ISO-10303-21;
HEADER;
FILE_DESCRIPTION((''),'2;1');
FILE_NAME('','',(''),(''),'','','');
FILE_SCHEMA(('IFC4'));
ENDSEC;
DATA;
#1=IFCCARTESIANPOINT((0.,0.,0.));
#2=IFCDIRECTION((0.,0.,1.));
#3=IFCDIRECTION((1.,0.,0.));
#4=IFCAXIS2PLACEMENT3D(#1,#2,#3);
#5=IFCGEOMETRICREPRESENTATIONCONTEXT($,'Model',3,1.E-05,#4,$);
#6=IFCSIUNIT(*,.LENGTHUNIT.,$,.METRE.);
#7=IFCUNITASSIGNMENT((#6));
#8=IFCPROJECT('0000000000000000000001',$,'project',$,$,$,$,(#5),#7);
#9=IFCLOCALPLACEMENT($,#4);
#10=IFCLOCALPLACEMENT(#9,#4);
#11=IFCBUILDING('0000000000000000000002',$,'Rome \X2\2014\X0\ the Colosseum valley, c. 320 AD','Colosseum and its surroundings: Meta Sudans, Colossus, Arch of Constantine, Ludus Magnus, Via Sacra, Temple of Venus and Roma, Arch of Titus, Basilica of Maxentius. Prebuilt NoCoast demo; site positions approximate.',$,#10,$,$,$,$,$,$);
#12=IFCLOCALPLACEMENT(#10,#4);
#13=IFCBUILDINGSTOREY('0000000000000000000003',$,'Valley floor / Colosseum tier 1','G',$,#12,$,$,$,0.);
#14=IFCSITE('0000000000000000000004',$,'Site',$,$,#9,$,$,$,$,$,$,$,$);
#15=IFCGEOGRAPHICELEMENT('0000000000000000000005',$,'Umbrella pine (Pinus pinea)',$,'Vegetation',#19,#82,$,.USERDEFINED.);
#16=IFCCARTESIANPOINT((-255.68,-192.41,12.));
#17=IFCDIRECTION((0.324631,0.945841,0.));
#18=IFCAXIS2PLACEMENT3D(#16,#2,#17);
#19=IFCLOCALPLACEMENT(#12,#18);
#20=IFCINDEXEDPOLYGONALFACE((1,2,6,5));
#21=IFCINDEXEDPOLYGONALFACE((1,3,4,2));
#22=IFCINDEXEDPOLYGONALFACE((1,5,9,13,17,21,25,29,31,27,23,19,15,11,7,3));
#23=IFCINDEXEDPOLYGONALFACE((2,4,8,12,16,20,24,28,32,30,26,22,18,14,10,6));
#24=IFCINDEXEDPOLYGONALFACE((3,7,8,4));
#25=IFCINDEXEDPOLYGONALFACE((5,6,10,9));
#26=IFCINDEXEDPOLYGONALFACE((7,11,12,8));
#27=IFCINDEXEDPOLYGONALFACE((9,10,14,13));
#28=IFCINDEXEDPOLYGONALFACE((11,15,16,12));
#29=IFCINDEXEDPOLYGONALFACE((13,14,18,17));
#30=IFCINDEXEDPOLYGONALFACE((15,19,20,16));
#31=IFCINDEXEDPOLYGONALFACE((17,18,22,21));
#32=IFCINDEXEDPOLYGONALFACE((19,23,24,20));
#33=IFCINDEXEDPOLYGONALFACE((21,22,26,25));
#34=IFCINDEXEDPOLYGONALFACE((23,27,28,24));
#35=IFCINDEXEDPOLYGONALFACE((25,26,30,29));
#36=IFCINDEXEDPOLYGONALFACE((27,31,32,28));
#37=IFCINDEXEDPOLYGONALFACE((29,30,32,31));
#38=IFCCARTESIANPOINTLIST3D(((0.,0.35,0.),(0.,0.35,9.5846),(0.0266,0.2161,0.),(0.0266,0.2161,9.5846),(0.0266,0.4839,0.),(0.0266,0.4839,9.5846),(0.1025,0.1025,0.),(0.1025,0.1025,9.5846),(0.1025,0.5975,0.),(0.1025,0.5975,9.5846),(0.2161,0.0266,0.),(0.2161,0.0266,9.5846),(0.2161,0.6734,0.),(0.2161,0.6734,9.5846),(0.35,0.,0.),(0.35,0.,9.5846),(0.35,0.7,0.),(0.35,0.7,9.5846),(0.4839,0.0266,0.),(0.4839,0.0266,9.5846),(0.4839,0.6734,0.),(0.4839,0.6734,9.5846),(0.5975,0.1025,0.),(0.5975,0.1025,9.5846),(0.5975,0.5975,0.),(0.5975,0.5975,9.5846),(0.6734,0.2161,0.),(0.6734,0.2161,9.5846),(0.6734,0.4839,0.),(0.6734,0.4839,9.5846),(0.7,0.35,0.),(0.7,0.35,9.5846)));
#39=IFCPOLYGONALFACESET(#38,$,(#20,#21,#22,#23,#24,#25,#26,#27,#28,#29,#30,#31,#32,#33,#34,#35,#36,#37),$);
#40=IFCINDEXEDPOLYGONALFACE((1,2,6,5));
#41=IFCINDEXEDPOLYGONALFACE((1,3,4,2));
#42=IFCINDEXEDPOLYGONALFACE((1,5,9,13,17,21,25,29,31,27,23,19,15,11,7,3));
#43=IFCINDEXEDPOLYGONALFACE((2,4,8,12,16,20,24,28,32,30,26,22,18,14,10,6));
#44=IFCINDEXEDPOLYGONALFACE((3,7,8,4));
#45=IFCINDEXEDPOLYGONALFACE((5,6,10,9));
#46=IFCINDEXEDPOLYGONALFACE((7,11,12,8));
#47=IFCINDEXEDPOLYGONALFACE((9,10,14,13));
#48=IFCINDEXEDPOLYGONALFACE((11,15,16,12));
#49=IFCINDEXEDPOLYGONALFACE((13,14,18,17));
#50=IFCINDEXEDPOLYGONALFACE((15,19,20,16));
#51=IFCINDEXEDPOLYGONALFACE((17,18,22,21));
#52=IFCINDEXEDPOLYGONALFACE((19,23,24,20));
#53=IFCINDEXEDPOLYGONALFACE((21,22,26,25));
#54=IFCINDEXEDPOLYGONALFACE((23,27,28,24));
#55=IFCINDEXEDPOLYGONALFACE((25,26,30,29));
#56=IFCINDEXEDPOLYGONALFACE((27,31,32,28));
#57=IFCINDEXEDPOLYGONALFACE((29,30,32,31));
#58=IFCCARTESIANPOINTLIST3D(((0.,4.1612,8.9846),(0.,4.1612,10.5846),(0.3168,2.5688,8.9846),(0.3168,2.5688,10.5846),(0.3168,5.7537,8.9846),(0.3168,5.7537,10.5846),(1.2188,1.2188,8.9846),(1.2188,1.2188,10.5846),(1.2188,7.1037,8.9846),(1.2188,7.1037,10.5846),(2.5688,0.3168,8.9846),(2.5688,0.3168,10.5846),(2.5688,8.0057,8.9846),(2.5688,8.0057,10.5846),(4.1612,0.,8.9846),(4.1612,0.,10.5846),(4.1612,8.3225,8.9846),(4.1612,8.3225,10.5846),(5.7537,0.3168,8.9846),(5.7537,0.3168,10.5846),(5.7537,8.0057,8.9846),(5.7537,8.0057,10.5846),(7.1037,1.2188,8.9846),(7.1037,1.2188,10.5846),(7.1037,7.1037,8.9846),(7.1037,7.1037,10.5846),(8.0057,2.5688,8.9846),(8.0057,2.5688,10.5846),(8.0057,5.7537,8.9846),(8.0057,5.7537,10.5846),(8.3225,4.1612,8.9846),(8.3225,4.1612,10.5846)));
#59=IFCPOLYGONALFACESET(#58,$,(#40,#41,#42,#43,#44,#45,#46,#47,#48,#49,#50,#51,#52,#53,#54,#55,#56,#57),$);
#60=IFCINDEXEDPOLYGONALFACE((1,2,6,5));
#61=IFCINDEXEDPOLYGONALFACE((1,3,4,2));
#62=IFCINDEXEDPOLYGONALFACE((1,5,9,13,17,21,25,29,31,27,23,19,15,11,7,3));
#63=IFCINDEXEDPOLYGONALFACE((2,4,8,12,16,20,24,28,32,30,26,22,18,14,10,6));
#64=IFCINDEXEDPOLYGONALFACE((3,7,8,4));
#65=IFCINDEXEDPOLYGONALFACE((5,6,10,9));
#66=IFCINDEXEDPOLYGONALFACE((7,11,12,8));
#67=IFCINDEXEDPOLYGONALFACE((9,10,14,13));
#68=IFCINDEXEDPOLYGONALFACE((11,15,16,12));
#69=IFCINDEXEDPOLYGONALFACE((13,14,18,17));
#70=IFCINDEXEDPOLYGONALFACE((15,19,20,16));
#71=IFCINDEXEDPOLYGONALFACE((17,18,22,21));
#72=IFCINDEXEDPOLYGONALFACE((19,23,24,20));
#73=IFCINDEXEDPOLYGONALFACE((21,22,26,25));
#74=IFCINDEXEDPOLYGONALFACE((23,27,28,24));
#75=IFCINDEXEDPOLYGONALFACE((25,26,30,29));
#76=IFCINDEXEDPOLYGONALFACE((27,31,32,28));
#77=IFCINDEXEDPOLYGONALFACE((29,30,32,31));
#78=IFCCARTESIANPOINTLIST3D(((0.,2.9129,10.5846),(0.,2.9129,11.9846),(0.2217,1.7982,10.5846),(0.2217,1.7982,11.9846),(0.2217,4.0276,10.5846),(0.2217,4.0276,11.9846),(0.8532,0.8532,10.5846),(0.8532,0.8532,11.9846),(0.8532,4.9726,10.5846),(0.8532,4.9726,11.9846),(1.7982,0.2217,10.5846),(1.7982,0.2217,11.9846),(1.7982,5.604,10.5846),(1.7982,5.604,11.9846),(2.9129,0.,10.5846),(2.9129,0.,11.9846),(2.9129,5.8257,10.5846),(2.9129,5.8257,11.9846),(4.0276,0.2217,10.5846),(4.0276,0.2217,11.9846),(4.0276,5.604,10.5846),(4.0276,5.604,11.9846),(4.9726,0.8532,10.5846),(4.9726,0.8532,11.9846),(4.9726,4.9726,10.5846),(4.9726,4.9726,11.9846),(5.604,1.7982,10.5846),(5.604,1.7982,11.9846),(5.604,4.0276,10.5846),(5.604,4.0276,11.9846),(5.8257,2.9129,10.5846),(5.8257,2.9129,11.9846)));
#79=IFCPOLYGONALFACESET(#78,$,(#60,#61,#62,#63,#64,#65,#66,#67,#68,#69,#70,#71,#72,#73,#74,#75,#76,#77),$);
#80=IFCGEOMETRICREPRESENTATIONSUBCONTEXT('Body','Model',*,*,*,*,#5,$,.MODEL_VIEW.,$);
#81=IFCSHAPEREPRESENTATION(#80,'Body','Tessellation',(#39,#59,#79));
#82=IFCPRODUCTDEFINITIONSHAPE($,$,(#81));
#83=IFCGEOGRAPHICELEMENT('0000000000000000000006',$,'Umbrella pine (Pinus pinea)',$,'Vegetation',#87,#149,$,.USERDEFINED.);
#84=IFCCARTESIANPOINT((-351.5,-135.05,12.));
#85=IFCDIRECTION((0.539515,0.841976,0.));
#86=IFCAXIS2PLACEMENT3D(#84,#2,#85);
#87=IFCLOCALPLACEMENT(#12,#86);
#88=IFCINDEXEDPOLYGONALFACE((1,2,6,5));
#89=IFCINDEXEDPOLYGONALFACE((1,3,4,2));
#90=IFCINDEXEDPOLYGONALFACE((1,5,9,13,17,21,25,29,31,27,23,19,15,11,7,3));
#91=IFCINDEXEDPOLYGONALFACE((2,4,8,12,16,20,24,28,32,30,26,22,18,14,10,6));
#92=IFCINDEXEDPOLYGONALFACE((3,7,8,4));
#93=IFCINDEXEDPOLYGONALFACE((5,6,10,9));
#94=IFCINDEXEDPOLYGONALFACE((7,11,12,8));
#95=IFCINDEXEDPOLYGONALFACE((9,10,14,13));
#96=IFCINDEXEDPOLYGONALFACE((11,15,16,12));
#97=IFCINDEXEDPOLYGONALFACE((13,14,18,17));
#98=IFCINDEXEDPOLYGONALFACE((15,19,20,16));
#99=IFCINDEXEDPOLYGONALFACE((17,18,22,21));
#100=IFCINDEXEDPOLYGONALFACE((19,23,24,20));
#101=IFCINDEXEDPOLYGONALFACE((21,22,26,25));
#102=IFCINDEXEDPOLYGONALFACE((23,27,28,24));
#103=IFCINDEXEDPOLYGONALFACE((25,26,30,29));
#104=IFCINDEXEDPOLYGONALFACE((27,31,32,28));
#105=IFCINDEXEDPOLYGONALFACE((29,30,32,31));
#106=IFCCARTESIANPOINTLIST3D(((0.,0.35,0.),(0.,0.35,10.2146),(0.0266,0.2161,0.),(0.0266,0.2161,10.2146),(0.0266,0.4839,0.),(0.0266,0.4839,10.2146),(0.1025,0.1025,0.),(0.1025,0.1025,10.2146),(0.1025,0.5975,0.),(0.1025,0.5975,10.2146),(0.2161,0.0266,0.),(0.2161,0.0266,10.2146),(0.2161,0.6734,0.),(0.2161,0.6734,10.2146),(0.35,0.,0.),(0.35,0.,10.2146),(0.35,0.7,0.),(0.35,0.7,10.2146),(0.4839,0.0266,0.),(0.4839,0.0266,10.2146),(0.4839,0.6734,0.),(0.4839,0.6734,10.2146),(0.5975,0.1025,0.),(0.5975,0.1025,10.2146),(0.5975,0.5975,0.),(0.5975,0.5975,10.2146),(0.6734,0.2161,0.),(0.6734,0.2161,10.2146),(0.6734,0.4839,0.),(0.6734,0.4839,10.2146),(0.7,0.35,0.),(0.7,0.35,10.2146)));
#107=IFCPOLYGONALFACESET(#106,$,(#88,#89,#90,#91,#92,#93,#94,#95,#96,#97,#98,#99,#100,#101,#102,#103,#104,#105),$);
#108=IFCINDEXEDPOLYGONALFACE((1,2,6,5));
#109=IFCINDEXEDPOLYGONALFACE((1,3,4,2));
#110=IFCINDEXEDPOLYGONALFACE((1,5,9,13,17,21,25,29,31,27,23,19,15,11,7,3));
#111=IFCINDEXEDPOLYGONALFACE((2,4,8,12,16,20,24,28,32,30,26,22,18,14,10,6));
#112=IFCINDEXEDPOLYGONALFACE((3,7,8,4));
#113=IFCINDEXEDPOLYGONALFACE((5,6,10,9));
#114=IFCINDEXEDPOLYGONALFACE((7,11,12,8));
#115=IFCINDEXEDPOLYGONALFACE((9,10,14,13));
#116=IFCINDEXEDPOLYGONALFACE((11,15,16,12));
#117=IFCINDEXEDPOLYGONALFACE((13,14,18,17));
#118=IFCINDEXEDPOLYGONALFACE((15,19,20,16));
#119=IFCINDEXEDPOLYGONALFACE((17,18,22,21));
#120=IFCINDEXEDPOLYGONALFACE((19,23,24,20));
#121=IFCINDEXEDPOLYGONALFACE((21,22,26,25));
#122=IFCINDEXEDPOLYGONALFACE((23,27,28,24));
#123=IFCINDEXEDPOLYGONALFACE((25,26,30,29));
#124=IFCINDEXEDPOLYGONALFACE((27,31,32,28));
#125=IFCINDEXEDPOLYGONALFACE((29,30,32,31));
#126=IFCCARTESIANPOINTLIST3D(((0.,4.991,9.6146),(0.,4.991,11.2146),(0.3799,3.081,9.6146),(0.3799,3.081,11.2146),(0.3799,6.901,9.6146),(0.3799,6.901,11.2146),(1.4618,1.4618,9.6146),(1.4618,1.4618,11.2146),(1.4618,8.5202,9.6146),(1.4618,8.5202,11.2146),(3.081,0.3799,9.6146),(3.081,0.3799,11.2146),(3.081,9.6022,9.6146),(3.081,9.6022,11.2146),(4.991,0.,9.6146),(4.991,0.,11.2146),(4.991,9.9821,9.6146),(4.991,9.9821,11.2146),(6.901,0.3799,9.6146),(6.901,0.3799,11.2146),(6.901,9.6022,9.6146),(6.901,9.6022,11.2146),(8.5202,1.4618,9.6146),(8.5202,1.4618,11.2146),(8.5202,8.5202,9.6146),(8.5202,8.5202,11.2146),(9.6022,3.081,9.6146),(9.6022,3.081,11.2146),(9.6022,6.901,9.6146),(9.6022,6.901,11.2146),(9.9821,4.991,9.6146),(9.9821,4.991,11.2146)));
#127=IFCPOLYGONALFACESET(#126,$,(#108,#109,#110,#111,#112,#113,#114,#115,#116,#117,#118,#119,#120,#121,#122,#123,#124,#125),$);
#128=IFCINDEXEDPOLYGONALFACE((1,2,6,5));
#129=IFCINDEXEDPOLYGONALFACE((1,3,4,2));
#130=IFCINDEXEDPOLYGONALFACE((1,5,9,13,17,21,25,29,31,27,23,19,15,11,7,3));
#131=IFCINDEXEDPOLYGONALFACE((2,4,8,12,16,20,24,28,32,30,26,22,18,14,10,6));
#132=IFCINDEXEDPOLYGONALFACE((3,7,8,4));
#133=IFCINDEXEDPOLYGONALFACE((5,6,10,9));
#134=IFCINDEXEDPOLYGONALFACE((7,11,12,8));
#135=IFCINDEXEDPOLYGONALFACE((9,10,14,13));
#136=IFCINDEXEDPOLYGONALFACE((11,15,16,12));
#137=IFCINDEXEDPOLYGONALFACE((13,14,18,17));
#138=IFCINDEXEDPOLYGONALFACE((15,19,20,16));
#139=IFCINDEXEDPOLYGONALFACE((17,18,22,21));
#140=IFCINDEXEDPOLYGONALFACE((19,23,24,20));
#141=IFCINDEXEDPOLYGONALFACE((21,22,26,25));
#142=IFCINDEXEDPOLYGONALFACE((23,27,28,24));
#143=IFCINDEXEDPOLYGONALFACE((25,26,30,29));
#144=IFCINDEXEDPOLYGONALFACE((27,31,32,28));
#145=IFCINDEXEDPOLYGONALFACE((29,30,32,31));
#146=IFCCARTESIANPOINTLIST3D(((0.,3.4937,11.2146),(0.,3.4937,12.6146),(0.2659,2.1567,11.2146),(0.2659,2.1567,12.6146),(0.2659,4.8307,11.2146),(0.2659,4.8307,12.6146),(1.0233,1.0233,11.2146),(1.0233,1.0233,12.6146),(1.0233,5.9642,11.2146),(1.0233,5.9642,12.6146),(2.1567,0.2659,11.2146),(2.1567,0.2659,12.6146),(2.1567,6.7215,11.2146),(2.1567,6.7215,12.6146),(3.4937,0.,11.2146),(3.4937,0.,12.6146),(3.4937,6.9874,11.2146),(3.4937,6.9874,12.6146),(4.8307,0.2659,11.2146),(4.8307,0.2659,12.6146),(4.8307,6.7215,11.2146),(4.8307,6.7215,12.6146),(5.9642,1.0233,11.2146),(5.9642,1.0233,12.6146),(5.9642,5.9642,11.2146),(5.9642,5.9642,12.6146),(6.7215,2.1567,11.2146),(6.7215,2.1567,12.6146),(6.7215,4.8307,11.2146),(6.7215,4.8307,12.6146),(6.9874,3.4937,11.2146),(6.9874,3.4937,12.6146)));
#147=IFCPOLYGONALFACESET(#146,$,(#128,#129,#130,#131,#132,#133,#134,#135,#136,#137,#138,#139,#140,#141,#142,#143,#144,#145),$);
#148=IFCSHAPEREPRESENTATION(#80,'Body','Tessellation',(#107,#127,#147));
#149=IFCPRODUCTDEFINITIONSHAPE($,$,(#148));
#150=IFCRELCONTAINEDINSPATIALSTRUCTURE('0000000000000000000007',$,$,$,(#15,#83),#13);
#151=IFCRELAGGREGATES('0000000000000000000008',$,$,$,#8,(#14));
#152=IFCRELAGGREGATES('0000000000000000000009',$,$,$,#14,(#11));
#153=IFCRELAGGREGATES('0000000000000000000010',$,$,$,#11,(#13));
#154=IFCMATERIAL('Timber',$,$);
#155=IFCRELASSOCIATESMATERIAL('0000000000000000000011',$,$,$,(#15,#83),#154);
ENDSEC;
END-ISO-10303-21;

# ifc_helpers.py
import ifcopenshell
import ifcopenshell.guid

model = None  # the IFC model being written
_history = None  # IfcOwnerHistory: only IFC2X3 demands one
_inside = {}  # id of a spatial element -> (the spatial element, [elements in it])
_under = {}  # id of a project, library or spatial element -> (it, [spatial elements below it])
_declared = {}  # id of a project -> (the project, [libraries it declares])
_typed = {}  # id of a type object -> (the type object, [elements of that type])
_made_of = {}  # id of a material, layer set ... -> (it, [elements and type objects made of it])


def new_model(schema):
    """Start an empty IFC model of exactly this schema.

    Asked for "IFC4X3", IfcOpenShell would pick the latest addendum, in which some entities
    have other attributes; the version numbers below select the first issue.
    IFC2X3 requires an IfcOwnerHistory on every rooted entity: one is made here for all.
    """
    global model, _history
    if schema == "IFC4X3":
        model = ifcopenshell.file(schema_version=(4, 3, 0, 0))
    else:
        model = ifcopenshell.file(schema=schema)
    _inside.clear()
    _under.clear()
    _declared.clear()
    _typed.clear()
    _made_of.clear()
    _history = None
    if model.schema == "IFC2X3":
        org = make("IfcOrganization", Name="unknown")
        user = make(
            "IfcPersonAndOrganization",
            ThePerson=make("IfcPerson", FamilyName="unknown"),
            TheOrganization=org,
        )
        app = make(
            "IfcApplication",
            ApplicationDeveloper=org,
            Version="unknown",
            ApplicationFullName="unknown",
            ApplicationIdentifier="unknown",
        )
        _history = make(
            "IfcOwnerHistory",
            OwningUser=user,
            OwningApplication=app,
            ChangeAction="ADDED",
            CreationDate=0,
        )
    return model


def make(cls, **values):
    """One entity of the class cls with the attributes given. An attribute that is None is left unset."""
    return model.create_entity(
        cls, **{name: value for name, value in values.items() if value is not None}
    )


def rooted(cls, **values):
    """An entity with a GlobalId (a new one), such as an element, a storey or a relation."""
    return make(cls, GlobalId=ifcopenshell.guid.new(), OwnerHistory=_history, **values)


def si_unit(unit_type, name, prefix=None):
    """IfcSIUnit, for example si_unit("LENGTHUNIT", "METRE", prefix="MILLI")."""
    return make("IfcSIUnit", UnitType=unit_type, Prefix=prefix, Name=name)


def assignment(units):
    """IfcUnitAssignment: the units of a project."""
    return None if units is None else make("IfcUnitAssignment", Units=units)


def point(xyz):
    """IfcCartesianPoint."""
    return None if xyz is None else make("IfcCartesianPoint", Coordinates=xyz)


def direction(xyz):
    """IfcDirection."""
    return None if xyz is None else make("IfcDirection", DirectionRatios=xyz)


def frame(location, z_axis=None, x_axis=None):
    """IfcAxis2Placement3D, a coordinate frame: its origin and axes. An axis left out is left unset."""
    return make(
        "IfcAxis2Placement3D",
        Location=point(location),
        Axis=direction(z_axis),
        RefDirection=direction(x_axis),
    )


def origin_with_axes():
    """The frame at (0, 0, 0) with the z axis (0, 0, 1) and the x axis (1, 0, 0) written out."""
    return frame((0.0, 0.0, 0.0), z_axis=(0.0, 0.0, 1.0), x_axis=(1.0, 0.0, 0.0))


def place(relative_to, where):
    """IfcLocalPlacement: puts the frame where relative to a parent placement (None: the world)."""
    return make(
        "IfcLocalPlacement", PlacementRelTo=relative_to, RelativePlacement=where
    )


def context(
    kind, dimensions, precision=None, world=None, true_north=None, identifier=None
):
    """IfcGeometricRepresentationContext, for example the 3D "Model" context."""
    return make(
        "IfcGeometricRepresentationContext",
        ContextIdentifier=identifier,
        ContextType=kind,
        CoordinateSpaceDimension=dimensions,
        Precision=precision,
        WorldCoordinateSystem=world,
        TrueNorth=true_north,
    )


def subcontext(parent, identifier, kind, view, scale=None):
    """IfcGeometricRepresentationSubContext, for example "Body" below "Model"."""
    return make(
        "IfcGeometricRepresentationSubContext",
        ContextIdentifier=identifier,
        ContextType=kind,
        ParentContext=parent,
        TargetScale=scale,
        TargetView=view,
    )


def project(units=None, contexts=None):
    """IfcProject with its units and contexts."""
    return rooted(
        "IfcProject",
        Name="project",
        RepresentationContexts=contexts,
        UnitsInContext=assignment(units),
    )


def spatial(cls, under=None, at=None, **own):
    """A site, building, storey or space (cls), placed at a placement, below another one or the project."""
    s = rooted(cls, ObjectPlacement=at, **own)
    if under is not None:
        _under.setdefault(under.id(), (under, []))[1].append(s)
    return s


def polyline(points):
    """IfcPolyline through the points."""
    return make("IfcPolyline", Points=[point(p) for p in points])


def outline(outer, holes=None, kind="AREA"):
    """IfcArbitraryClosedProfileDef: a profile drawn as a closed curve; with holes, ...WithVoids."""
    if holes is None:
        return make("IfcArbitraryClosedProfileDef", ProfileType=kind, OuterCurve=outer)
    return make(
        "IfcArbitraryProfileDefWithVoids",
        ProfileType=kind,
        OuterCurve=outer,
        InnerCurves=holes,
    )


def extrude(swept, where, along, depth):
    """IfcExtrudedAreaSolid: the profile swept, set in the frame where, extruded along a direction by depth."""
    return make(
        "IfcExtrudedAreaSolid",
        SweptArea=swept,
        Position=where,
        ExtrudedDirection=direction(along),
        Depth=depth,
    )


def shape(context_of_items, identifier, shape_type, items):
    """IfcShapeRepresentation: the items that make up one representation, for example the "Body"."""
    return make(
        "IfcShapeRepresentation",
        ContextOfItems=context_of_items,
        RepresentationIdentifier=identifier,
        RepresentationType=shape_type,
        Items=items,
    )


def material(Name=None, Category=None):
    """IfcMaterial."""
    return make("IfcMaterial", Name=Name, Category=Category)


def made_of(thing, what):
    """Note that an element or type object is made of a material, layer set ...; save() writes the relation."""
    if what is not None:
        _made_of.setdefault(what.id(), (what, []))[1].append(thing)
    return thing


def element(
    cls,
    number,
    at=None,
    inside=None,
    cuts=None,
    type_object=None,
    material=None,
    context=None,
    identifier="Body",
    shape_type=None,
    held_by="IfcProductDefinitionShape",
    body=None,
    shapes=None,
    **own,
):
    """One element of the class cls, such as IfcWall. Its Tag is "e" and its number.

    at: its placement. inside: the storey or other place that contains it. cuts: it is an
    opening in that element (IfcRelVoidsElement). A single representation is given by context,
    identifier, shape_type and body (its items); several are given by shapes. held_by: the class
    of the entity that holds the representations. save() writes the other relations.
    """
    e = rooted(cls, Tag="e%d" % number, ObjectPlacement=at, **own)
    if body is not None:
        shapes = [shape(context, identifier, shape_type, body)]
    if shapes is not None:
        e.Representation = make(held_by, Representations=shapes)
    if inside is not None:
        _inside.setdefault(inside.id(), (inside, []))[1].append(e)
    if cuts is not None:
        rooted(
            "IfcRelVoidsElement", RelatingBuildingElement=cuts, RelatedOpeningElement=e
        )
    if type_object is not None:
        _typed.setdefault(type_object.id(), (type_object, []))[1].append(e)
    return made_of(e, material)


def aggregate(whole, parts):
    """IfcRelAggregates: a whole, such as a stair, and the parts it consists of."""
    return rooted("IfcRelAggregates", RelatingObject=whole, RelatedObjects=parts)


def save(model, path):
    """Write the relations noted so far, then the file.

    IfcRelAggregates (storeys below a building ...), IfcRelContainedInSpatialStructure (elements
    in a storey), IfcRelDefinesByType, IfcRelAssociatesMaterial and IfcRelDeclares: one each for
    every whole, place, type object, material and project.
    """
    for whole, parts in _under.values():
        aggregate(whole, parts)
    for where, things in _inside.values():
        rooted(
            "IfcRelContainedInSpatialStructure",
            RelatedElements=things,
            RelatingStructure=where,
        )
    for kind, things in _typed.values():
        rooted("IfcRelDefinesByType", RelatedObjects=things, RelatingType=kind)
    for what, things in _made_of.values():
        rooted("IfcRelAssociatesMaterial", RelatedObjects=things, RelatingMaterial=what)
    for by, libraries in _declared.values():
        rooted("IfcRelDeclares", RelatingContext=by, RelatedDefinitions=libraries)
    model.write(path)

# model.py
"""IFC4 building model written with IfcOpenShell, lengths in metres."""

from ifc_helpers import new_model, si_unit, frame, origin_with_axes, place, context, subcontext, project, spatial, polyline, outline, extrude, material, element, save


model = new_model("IFC4")

# Units and contexts
model_context = context("Model", 3, precision=1e-05, world=origin_with_axes())
body_context = subcontext(model_context, "Body", "Model", "MODEL_VIEW")
ifc_project = project(units=[si_unit("LENGTHUNIT", "METRE")], contexts=[model_context])

# Site, building, storey
site_placement = place(None, origin_with_axes())
site = spatial("IfcSite", under=ifc_project, at=site_placement, Name="Site")
building_placement = place(site_placement, origin_with_axes())
building = spatial("IfcBuilding", under=site, at=building_placement, Name="Rome — the Colosseum valley, c. 320 AD", Description="Colosseum and its surroundings: Meta Sudans, Colossus, Arch of Constantine, Ludus Magnus, Via Sacra, Temple of Venus and Roma, Arch of Titus, Basilica of Maxentius. Prebuilt NoCoast demo; site positions approximate.")
storey_placement = place(building_placement, origin_with_axes())
storey = spatial("IfcBuildingStorey", under=building, at=storey_placement, Name="Valley floor / Colosseum tier 1", Description="G", Elevation=0.0)

# Shared definitions
ifc_material_1 = material(Name="Timber")

# Geographic elements
geographic_element_1_placement = place(storey_placement, frame((-255.68, -192.41, 12.0), z_axis=(0.0, 0.0, 1.0), x_axis=(0.324631, 0.945841, 0.0)))
element("IfcGeographicElement", 1, at=geographic_element_1_placement, inside=storey, material=ifc_material_1, Name="Umbrella pine (Pinus pinea)", ObjectType="Vegetation", PredefinedType="USERDEFINED", context=body_context, shape_type="SweptSolid", body=[
    extrude(outline(polyline([(0.7, 0.35), (0.6734, 0.4839), (0.5975, 0.5975), (0.4839, 0.6734), (0.35, 0.7), (0.2161, 0.6734), (0.1025, 0.5975), (0.0266, 0.4839), (0.0, 0.35), (0.0266, 0.2161), (0.1025, 0.1025), (0.2161, 0.0266), (0.35, 0.0), (0.4839, 0.0266), (0.5975, 0.1025), (0.6734, 0.2161), (0.7, 0.35)])), origin_with_axes(), (0.0, 0.0, 1.0), 9.5846),
    extrude(outline(polyline([(8.3225, 4.1612), (8.0057, 5.7537), (7.1037, 7.1037), (5.7537, 8.0057), (4.1612, 8.3225), (2.5688, 8.0057), (1.2188, 7.1037), (0.3168, 5.7537), (0.0, 4.1612), (0.3168, 2.5688), (1.2188, 1.2188), (2.5688, 0.3168), (4.1612, 0.0), (5.7537, 0.3168), (7.1037, 1.2188), (8.0057, 2.5688), (8.3225, 4.1612)])), frame((0.0, 0.0, 8.9846), z_axis=(0.0, 0.0, 1.0), x_axis=(1.0, 0.0, 0.0)), (0.0, 0.0, 1.0), 1.6),
    extrude(outline(polyline([(5.8257, 2.9129), (5.604, 4.0276), (4.9726, 4.9726), (4.0276, 5.604), (2.9129, 5.8257), (1.7982, 5.604), (0.8532, 4.9726), (0.2217, 4.0276), (0.0, 2.9129), (0.2217, 1.7982), (0.8532, 0.8532), (1.7982, 0.2217), (2.9129, 0.0), (4.0276, 0.2217), (4.9726, 0.8532), (5.604, 1.7982), (5.8257, 2.9129)])), frame((0.0, 0.0, 10.5846), z_axis=(0.0, 0.0, 1.0), x_axis=(1.0, 0.0, 0.0)), (0.0, 0.0, 1.0), 1.4),
])
geographic_element_2_placement = place(storey_placement, frame((-351.5, -135.05, 12.0), z_axis=(0.0, 0.0, 1.0), x_axis=(0.539515, 0.841976, 0.0)))
element("IfcGeographicElement", 2, at=geographic_element_2_placement, inside=storey, material=ifc_material_1, Name="Umbrella pine (Pinus pinea)", ObjectType="Vegetation", PredefinedType="USERDEFINED", context=body_context, shape_type="SweptSolid", body=[
    extrude(outline(polyline([(0.7, 0.35), (0.6734, 0.4839), (0.5975, 0.5975), (0.4839, 0.6734), (0.35, 0.7), (0.2161, 0.6734), (0.1025, 0.5975), (0.0266, 0.4839), (0.0, 0.35), (0.0266, 0.2161), (0.1025, 0.1025), (0.2161, 0.0266), (0.35, 0.0), (0.4839, 0.0266), (0.5975, 0.1025), (0.6734, 0.2161), (0.7, 0.35)])), origin_with_axes(), (0.0, 0.0, 1.0), 10.2146),
    extrude(outline(polyline([(9.9821, 4.991), (9.6022, 6.901), (8.5202, 8.5202), (6.901, 9.6022), (4.991, 9.9821), (3.081, 9.6022), (1.4618, 8.5202), (0.3799, 6.901), (0.0, 4.991), (0.3799, 3.081), (1.4618, 1.4618), (3.081, 0.3799), (4.991, 0.0), (6.901, 0.3799), (8.5202, 1.4618), (9.6022, 3.081), (9.9821, 4.991)])), frame((0.0, 0.0, 9.6146), z_axis=(0.0, 0.0, 1.0), x_axis=(1.0, 0.0, 0.0)), (0.0, 0.0, 1.0), 1.6),
    extrude(outline(polyline([(6.9874, 3.4937), (6.7215, 4.8307), (5.9642, 5.9642), (4.8307, 6.7215), (3.4937, 6.9874), (2.1567, 6.7215), (1.0233, 5.9642), (0.2659, 4.8307), (0.0, 3.4937), (0.2659, 2.1567), (1.0233, 1.0233), (2.1567, 0.2659), (3.4937, 0.0), (4.8307, 0.2659), (5.9642, 1.0233), (6.7215, 2.1567), (6.9874, 3.4937)])), frame((0.0, 0.0, 11.2146), z_axis=(0.0, 0.0, 1.0), x_axis=(1.0, 0.0, 0.0)), (0.0, 0.0, 1.0), 1.4),
])

save(model, "model.ifc")
